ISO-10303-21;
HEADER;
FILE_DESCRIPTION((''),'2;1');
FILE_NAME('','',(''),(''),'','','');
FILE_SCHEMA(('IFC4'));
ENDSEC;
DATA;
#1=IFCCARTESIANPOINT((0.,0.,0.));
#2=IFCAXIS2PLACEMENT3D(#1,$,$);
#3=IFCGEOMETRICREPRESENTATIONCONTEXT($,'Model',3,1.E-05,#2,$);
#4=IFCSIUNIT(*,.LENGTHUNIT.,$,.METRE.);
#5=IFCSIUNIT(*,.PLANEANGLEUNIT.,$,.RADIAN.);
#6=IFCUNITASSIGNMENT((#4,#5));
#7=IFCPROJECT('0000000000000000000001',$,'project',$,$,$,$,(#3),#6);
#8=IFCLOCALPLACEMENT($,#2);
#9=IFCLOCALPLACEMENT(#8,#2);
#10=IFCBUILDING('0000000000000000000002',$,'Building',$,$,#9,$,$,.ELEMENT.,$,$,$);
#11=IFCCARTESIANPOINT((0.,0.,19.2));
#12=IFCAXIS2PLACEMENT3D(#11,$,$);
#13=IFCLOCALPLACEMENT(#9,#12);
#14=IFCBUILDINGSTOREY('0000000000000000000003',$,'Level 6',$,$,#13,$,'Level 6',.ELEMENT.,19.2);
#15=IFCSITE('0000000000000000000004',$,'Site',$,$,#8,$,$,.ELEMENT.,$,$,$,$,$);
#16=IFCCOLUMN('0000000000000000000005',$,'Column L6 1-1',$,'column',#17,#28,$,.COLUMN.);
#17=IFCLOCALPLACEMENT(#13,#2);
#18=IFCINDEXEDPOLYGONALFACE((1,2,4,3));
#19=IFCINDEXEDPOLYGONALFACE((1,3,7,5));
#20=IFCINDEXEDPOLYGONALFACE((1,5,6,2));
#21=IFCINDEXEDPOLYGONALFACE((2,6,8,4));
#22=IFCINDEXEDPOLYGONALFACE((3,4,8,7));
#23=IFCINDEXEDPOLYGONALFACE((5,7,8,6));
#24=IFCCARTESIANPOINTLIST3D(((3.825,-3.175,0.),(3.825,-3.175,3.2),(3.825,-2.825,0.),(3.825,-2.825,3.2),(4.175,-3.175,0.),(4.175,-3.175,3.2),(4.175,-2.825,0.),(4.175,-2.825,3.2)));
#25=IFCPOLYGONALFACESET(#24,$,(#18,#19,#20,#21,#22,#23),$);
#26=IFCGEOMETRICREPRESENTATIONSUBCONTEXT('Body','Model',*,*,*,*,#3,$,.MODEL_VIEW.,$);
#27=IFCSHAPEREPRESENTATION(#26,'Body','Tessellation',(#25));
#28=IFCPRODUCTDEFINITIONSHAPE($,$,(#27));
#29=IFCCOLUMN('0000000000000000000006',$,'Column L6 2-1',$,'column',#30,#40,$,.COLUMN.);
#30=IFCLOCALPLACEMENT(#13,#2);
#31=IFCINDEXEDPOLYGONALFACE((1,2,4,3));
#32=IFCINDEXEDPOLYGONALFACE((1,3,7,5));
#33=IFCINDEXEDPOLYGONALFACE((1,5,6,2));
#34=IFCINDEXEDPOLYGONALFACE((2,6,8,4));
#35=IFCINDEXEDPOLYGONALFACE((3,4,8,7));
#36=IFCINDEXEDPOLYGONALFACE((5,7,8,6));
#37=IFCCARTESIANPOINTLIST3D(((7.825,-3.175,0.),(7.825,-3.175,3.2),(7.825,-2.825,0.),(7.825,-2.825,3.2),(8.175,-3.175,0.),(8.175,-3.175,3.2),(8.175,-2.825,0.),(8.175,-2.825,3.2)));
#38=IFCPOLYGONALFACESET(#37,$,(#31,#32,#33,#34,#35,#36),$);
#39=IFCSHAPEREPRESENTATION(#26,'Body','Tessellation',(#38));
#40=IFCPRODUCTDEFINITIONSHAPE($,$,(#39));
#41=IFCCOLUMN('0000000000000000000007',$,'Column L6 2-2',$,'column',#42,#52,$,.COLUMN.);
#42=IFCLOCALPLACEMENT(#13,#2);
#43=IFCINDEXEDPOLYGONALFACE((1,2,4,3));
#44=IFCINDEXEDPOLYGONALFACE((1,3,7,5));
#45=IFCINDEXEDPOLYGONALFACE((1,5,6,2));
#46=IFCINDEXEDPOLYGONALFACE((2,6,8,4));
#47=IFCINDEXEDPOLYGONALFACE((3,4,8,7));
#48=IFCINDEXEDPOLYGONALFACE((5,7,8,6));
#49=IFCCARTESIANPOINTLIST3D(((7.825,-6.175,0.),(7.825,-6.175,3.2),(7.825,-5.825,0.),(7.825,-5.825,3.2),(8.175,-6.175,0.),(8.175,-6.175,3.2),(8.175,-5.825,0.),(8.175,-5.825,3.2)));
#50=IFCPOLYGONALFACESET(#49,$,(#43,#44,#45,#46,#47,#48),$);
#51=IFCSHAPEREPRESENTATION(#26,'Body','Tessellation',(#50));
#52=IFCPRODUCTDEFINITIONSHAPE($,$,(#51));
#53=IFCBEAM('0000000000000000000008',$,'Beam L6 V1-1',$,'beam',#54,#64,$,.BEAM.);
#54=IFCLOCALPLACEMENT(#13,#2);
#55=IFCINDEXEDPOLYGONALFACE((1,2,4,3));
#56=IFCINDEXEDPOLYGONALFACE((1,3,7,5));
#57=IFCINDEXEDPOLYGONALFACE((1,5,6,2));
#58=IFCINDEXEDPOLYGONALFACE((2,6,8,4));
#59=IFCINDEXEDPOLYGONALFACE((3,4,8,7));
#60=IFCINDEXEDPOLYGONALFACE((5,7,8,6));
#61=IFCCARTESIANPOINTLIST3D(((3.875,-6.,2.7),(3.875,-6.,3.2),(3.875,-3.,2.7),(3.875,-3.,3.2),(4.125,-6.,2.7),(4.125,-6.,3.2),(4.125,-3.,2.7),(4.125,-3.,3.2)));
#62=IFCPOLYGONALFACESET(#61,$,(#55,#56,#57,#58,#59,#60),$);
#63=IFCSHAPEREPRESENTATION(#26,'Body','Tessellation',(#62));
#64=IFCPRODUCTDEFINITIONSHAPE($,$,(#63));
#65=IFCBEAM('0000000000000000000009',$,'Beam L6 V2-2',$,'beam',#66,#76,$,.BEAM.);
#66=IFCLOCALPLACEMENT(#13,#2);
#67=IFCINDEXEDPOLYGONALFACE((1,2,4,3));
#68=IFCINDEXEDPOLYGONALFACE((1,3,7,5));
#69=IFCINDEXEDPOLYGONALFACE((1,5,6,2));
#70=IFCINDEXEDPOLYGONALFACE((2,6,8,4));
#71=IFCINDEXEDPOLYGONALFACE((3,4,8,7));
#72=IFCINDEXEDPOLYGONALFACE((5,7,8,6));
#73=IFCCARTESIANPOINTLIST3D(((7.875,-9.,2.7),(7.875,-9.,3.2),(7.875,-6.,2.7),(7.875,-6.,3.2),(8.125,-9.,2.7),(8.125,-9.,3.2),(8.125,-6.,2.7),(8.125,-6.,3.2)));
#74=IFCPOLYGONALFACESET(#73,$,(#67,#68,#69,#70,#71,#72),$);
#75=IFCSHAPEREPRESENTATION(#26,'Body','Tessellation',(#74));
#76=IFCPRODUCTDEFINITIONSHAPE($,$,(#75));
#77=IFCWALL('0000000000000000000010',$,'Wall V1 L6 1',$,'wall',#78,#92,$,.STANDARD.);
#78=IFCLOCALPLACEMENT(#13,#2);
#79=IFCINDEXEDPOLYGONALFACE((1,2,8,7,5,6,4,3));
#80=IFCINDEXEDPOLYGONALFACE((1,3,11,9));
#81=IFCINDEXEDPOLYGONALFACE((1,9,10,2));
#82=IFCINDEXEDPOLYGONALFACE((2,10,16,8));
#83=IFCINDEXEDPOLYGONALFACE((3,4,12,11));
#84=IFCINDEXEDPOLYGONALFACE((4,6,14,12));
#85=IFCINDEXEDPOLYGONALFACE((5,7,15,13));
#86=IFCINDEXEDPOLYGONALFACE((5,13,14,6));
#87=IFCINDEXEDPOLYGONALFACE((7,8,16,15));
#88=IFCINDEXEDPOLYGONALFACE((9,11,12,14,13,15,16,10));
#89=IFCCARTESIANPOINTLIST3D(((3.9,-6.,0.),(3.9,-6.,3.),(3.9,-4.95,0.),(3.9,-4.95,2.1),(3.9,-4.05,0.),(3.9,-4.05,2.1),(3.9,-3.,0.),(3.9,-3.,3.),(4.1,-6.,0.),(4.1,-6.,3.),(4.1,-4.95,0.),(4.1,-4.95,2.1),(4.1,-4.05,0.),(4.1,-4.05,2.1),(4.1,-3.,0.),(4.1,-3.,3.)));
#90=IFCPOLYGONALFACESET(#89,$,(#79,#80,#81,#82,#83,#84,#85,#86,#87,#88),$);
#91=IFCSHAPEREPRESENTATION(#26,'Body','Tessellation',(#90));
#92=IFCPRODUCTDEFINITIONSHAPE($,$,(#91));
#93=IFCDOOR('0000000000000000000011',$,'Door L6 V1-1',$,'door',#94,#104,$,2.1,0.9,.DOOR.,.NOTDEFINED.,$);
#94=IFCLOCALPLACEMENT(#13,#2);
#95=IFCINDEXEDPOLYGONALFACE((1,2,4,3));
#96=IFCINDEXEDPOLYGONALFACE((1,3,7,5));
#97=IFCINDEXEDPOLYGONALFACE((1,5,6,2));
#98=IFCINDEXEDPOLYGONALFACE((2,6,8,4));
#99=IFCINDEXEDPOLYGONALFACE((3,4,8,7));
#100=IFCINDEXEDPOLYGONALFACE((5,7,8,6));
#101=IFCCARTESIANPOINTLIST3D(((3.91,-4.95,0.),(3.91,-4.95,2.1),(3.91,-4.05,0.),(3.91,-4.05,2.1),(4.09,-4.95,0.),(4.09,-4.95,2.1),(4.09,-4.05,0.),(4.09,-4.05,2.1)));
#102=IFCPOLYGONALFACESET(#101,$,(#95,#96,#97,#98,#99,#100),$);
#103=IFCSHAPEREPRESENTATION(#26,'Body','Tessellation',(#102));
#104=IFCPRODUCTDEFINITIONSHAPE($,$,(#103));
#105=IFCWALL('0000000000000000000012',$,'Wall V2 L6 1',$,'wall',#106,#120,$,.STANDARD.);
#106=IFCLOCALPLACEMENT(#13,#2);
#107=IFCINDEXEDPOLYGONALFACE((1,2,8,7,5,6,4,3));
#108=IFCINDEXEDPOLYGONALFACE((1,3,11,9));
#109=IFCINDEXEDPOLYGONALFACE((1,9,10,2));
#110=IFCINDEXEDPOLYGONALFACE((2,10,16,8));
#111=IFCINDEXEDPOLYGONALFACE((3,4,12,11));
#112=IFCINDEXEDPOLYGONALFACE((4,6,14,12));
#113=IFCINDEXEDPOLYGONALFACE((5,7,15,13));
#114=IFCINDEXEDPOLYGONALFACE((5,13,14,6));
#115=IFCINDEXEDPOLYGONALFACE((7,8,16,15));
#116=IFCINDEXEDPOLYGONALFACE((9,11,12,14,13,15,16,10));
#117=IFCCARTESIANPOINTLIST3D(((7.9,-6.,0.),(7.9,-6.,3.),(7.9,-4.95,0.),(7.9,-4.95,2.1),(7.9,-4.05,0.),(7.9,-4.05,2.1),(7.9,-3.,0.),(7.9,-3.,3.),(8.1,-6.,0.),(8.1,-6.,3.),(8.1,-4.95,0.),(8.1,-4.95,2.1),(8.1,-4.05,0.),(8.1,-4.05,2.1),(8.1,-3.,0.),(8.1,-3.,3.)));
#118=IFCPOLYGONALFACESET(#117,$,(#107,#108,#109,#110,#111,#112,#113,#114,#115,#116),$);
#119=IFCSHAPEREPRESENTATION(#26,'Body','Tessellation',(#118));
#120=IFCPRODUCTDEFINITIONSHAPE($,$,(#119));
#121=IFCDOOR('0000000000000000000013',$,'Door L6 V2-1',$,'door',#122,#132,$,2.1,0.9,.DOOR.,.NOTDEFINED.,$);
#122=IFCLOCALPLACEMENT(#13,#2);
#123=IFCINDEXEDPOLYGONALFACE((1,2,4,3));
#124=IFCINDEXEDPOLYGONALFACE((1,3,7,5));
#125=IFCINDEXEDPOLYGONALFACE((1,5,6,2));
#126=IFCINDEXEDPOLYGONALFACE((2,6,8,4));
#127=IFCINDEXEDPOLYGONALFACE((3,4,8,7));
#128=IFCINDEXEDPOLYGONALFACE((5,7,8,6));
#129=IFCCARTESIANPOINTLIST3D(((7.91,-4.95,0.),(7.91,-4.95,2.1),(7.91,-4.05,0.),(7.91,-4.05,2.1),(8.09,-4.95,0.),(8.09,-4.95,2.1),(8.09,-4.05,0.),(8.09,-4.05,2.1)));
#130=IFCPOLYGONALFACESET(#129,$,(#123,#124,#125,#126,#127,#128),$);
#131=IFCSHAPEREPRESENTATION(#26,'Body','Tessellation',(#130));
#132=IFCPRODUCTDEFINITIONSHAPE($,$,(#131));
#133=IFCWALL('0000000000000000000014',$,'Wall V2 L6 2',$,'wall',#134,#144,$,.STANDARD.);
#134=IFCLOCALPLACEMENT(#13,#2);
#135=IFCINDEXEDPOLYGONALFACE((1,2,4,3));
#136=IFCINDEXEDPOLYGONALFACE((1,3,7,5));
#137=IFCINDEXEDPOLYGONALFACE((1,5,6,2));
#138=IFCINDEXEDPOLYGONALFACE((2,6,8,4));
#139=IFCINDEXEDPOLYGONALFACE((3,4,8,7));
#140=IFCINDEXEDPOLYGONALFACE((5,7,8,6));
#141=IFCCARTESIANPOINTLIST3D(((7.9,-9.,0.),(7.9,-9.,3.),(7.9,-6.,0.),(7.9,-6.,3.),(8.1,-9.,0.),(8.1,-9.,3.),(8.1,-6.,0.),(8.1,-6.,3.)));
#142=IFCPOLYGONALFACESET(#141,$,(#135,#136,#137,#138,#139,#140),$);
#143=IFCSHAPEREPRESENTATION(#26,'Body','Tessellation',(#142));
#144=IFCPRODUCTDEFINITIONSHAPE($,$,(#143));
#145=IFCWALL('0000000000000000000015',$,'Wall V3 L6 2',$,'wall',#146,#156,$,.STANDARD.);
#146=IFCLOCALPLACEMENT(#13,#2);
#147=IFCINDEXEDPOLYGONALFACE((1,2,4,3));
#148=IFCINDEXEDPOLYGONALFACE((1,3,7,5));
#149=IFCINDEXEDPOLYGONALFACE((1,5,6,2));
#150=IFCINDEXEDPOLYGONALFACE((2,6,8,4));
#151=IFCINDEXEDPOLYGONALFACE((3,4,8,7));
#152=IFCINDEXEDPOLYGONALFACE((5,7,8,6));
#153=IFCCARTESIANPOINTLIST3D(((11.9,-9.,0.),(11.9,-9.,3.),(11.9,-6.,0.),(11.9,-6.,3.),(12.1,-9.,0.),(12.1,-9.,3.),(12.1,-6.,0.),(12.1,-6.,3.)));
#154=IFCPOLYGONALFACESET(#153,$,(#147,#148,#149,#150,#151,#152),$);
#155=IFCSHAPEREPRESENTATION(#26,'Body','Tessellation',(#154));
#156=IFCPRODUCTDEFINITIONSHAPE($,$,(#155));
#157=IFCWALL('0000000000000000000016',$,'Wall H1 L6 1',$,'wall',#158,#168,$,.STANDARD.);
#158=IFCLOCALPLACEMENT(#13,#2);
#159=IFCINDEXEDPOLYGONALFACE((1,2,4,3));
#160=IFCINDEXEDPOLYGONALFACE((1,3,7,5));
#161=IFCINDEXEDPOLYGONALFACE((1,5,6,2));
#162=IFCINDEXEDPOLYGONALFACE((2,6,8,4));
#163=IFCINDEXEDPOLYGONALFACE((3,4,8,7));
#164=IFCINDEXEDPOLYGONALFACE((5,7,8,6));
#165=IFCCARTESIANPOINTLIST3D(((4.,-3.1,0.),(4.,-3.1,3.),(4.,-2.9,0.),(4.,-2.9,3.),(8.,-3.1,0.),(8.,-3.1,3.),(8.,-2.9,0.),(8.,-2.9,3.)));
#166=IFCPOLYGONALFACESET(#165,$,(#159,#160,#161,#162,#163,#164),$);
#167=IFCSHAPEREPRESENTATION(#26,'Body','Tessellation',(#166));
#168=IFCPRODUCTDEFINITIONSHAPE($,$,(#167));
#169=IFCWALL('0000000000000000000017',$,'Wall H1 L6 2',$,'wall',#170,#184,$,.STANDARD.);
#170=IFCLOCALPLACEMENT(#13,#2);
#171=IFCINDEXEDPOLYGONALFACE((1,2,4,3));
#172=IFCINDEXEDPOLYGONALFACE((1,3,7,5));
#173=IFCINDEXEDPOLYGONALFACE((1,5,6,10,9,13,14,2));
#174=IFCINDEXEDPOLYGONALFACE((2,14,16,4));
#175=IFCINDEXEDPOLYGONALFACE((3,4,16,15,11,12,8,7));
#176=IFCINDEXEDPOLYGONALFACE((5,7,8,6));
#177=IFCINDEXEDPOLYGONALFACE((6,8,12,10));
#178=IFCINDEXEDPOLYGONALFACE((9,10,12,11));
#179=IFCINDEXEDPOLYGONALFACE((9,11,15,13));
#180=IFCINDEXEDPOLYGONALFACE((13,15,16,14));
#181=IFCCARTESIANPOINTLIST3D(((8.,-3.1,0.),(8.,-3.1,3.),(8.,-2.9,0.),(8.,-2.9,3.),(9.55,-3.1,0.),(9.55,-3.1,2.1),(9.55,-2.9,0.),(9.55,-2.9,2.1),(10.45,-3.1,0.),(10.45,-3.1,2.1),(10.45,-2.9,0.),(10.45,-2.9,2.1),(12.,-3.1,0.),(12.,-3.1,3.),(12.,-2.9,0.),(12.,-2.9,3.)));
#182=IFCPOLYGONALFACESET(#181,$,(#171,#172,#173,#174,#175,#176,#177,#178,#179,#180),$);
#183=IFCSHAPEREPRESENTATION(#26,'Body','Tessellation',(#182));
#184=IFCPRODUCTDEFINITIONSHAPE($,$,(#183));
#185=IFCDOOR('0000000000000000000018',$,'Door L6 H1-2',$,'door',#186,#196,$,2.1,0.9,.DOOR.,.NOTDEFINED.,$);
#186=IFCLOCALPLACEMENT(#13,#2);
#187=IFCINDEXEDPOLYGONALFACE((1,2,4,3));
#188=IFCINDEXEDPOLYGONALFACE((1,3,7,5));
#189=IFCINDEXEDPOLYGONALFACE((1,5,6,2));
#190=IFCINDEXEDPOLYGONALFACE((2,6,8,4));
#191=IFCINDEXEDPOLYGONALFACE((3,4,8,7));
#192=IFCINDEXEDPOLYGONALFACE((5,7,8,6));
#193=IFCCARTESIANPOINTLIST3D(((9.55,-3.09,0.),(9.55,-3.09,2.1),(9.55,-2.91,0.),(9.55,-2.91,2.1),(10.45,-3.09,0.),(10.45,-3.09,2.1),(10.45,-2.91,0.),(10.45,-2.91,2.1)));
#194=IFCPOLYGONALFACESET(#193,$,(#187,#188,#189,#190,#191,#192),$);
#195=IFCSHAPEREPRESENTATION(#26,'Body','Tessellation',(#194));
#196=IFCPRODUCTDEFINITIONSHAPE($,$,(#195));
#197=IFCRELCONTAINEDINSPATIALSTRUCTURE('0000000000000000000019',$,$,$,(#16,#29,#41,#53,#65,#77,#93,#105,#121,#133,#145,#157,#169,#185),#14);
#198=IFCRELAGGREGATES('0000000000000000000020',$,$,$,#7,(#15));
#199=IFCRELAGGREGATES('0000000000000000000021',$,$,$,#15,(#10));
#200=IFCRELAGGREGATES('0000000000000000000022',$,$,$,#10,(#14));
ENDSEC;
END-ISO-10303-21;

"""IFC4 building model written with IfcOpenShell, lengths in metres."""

from ifc_helpers import new_model, si_unit, frame, frame_2d, origin, origin_2d, place, context, subcontext, project, spatial, rectangle, extrude, element, fill, save


model = new_model("IFC4")

# Units and contexts
model_context = context("Model", 3, precision=1e-05, world=origin())
body_context = subcontext(model_context, "Body", "Model", "MODEL_VIEW")
ifc_project = project(units=[si_unit("LENGTHUNIT", "METRE"), si_unit("PLANEANGLEUNIT", "RADIAN")], contexts=[model_context])

# Site, building, storey
site_placement = place(None, origin())
site = spatial("IfcSite", under=ifc_project, at=site_placement, Name="Site", CompositionType="ELEMENT")
building_placement = place(site_placement, origin())
building = spatial("IfcBuilding", under=site, at=building_placement, Name="Building", CompositionType="ELEMENT")
storey_placement = place(building_placement, frame((0.0, 0.0, 19.2)))
storey = spatial("IfcBuildingStorey", under=building, at=storey_placement, Name="Level 6", LongName="Level 6", CompositionType="ELEMENT", Elevation=19.2)

# Columns
for number, where, name in (
    (1, (4.0, -3.0, 0.0), "Column L6 1-1"),
    (2, (8.0, -3.0, 0.0), "Column L6 2-1"),
    (3, (8.0, -6.0, 0.0), "Column L6 2-2"),
):
    element("IfcColumn", number, at=place(storey_placement, frame(where)), inside=storey, Name=name, ObjectType="column", PredefinedType="COLUMN", context=body_context, shape_type="SweptSolid", body=[
        extrude(rectangle(XDim=0.35, YDim=0.35, at=origin_2d()), origin(), (0.0, 0.0, 1.0), 3.2),
    ])

# Beams
for number, where, z_axis, x_axis, name in (
    (4, (4.0, -3.0, 2.95), (0.0, -1.0, 0.0), (0.0, 0.0, 1.0), "Beam L6 V1-1"),
    (5, (8.0, -6.0, 2.95), (0.0, -1.0, 0.0), (0.0, 0.0, 1.0), "Beam L6 V2-2"),
):
    element("IfcBeam", number, at=place(storey_placement, frame(where, z_axis=z_axis, x_axis=x_axis)), inside=storey, Name=name, ObjectType="beam", PredefinedType="BEAM", context=body_context, shape_type="SweptSolid", body=[
        extrude(rectangle(XDim=0.5, YDim=0.25, at=origin_2d()), origin(), (0.0, 0.0, 1.0), 3.0),
    ])

# Walls, openings, doors
wall_1_placement = place(storey_placement, frame((4.0, -3.0, 0.0), z_axis=(0.0, 0.0, 1.0), x_axis=(0.0, -1.0, 0.0)))
wall_1 = element("IfcWall", 6, at=wall_1_placement, inside=storey, Name="Wall V1 L6 1", ObjectType="wall", PredefinedType="STANDARD", context=body_context, shape_type="SweptSolid", body=[
    extrude(rectangle(XDim=3.0, YDim=0.2, at=frame_2d((1.5, 0.0))), origin(), (0.0, 0.0, 1.0), 3.0),
])
opening_1_placement = place(storey_placement, frame((4.0, -4.5, 0.0), z_axis=(0.0, 0.0, 1.0), x_axis=(0.0, -1.0, 0.0)))
opening_1 = element("IfcOpeningElement", 7, at=opening_1_placement, cuts=wall_1, ObjectType="Opening", PredefinedType="OPENING", context=body_context, shape_type="SweptSolid", body=[
    extrude(rectangle(XDim=0.9, YDim=0.22, at=origin_2d()), origin(), (0.0, 0.0, 1.0), 2.1),
])
door_1_placement = place(storey_placement, frame((4.0, -4.5, 0.0), z_axis=(0.0, 0.0, 1.0), x_axis=(0.0, -1.0, 0.0)))
door_1 = element("IfcDoor", 8, at=door_1_placement, inside=storey, Name="Door L6 V1-1", ObjectType="door", OperationType="NOTDEFINED", OverallHeight=2.1, OverallWidth=0.9, PredefinedType="DOOR", context=body_context, shape_type="SweptSolid", body=[
    extrude(rectangle(XDim=0.9, YDim=0.18, at=origin_2d()), origin(), (0.0, 0.0, 1.0), 2.1),
])
fill(opening_1, door_1)
wall_2_placement = place(storey_placement, frame((8.0, -3.0, 0.0), z_axis=(0.0, 0.0, 1.0), x_axis=(0.0, -1.0, 0.0)))
wall_2 = element("IfcWall", 9, at=wall_2_placement, inside=storey, Name="Wall V2 L6 1", ObjectType="wall", PredefinedType="STANDARD", context=body_context, shape_type="SweptSolid", body=[
    extrude(rectangle(XDim=3.0, YDim=0.2, at=frame_2d((1.5, 0.0))), origin(), (0.0, 0.0, 1.0), 3.0),
])
opening_2_placement = place(storey_placement, frame((8.0, -4.5, 0.0), z_axis=(0.0, 0.0, 1.0), x_axis=(0.0, -1.0, 0.0)))
opening_2 = element("IfcOpeningElement", 10, at=opening_2_placement, cuts=wall_2, ObjectType="Opening", PredefinedType="OPENING", context=body_context, shape_type="SweptSolid", body=[
    extrude(rectangle(XDim=0.9, YDim=0.22, at=origin_2d()), origin(), (0.0, 0.0, 1.0), 2.1),
])
door_2_placement = place(storey_placement, frame((8.0, -4.5, 0.0), z_axis=(0.0, 0.0, 1.0), x_axis=(0.0, -1.0, 0.0)))
door_2 = element("IfcDoor", 11, at=door_2_placement, inside=storey, Name="Door L6 V2-1", ObjectType="door", OperationType="NOTDEFINED", OverallHeight=2.1, OverallWidth=0.9, PredefinedType="DOOR", context=body_context, shape_type="SweptSolid", body=[
    extrude(rectangle(XDim=0.9, YDim=0.18, at=origin_2d()), origin(), (0.0, 0.0, 1.0), 2.1),
])
fill(opening_2, door_2)

# Walls
for number, where, z_axis, x_axis, name in (
    (12, (8.0, -6.0, 0.0), (0.0, 0.0, 1.0), (0.0, -1.0, 0.0), "Wall V2 L6 2"),
    (13, (12.0, -6.0, 0.0), (0.0, 0.0, 1.0), (0.0, -1.0, 0.0), "Wall V3 L6 2"),
):
    element("IfcWall", number, at=place(storey_placement, frame(where, z_axis=z_axis, x_axis=x_axis)), inside=storey, Name=name, ObjectType="wall", PredefinedType="STANDARD", context=body_context, shape_type="SweptSolid", body=[
        extrude(rectangle(XDim=3.0, YDim=0.2, at=frame_2d((1.5, 0.0))), origin(), (0.0, 0.0, 1.0), 3.0),
    ])
wall_3_placement = place(storey_placement, frame((4.0, -3.0, 0.0), z_axis=(0.0, 0.0, 1.0), x_axis=(1.0, 0.0, 0.0)))
element("IfcWall", 14, at=wall_3_placement, inside=storey, Name="Wall H1 L6 1", ObjectType="wall", PredefinedType="STANDARD", context=body_context, shape_type="SweptSolid", body=[
    extrude(rectangle(XDim=4.0, YDim=0.2, at=frame_2d((2.0, 0.0))), origin(), (0.0, 0.0, 1.0), 3.0),
])

# Wall, opening, door
wall_4_placement = place(storey_placement, frame((8.0, -3.0, 0.0), z_axis=(0.0, 0.0, 1.0), x_axis=(1.0, 0.0, 0.0)))
wall_4 = element("IfcWall", 15, at=wall_4_placement, inside=storey, Name="Wall H1 L6 2", ObjectType="wall", PredefinedType="STANDARD", context=body_context, shape_type="SweptSolid", body=[
    extrude(rectangle(XDim=4.0, YDim=0.2, at=frame_2d((2.0, 0.0))), origin(), (0.0, 0.0, 1.0), 3.0),
])
opening_3_placement = place(storey_placement, frame((10.0, -3.0, 0.0), z_axis=(0.0, 0.0, 1.0), x_axis=(1.0, 0.0, 0.0)))
opening_3 = element("IfcOpeningElement", 16, at=opening_3_placement, cuts=wall_4, ObjectType="Opening", PredefinedType="OPENING", context=body_context, shape_type="SweptSolid", body=[
    extrude(rectangle(XDim=0.9, YDim=0.22, at=origin_2d()), origin(), (0.0, 0.0, 1.0), 2.1),
])
door_3_placement = place(storey_placement, frame((10.0, -3.0, 0.0), z_axis=(0.0, 0.0, 1.0), x_axis=(1.0, 0.0, 0.0)))
door_3 = element("IfcDoor", 17, at=door_3_placement, inside=storey, Name="Door L6 H1-2", ObjectType="door", OperationType="NOTDEFINED", OverallHeight=2.1, OverallWidth=0.9, PredefinedType="DOOR", context=body_context, shape_type="SweptSolid", body=[
    extrude(rectangle(XDim=0.9, YDim=0.18, at=origin_2d()), origin(), (0.0, 0.0, 1.0), 2.1),
])
fill(opening_3, door_3)

save(model, "model.ifc")
